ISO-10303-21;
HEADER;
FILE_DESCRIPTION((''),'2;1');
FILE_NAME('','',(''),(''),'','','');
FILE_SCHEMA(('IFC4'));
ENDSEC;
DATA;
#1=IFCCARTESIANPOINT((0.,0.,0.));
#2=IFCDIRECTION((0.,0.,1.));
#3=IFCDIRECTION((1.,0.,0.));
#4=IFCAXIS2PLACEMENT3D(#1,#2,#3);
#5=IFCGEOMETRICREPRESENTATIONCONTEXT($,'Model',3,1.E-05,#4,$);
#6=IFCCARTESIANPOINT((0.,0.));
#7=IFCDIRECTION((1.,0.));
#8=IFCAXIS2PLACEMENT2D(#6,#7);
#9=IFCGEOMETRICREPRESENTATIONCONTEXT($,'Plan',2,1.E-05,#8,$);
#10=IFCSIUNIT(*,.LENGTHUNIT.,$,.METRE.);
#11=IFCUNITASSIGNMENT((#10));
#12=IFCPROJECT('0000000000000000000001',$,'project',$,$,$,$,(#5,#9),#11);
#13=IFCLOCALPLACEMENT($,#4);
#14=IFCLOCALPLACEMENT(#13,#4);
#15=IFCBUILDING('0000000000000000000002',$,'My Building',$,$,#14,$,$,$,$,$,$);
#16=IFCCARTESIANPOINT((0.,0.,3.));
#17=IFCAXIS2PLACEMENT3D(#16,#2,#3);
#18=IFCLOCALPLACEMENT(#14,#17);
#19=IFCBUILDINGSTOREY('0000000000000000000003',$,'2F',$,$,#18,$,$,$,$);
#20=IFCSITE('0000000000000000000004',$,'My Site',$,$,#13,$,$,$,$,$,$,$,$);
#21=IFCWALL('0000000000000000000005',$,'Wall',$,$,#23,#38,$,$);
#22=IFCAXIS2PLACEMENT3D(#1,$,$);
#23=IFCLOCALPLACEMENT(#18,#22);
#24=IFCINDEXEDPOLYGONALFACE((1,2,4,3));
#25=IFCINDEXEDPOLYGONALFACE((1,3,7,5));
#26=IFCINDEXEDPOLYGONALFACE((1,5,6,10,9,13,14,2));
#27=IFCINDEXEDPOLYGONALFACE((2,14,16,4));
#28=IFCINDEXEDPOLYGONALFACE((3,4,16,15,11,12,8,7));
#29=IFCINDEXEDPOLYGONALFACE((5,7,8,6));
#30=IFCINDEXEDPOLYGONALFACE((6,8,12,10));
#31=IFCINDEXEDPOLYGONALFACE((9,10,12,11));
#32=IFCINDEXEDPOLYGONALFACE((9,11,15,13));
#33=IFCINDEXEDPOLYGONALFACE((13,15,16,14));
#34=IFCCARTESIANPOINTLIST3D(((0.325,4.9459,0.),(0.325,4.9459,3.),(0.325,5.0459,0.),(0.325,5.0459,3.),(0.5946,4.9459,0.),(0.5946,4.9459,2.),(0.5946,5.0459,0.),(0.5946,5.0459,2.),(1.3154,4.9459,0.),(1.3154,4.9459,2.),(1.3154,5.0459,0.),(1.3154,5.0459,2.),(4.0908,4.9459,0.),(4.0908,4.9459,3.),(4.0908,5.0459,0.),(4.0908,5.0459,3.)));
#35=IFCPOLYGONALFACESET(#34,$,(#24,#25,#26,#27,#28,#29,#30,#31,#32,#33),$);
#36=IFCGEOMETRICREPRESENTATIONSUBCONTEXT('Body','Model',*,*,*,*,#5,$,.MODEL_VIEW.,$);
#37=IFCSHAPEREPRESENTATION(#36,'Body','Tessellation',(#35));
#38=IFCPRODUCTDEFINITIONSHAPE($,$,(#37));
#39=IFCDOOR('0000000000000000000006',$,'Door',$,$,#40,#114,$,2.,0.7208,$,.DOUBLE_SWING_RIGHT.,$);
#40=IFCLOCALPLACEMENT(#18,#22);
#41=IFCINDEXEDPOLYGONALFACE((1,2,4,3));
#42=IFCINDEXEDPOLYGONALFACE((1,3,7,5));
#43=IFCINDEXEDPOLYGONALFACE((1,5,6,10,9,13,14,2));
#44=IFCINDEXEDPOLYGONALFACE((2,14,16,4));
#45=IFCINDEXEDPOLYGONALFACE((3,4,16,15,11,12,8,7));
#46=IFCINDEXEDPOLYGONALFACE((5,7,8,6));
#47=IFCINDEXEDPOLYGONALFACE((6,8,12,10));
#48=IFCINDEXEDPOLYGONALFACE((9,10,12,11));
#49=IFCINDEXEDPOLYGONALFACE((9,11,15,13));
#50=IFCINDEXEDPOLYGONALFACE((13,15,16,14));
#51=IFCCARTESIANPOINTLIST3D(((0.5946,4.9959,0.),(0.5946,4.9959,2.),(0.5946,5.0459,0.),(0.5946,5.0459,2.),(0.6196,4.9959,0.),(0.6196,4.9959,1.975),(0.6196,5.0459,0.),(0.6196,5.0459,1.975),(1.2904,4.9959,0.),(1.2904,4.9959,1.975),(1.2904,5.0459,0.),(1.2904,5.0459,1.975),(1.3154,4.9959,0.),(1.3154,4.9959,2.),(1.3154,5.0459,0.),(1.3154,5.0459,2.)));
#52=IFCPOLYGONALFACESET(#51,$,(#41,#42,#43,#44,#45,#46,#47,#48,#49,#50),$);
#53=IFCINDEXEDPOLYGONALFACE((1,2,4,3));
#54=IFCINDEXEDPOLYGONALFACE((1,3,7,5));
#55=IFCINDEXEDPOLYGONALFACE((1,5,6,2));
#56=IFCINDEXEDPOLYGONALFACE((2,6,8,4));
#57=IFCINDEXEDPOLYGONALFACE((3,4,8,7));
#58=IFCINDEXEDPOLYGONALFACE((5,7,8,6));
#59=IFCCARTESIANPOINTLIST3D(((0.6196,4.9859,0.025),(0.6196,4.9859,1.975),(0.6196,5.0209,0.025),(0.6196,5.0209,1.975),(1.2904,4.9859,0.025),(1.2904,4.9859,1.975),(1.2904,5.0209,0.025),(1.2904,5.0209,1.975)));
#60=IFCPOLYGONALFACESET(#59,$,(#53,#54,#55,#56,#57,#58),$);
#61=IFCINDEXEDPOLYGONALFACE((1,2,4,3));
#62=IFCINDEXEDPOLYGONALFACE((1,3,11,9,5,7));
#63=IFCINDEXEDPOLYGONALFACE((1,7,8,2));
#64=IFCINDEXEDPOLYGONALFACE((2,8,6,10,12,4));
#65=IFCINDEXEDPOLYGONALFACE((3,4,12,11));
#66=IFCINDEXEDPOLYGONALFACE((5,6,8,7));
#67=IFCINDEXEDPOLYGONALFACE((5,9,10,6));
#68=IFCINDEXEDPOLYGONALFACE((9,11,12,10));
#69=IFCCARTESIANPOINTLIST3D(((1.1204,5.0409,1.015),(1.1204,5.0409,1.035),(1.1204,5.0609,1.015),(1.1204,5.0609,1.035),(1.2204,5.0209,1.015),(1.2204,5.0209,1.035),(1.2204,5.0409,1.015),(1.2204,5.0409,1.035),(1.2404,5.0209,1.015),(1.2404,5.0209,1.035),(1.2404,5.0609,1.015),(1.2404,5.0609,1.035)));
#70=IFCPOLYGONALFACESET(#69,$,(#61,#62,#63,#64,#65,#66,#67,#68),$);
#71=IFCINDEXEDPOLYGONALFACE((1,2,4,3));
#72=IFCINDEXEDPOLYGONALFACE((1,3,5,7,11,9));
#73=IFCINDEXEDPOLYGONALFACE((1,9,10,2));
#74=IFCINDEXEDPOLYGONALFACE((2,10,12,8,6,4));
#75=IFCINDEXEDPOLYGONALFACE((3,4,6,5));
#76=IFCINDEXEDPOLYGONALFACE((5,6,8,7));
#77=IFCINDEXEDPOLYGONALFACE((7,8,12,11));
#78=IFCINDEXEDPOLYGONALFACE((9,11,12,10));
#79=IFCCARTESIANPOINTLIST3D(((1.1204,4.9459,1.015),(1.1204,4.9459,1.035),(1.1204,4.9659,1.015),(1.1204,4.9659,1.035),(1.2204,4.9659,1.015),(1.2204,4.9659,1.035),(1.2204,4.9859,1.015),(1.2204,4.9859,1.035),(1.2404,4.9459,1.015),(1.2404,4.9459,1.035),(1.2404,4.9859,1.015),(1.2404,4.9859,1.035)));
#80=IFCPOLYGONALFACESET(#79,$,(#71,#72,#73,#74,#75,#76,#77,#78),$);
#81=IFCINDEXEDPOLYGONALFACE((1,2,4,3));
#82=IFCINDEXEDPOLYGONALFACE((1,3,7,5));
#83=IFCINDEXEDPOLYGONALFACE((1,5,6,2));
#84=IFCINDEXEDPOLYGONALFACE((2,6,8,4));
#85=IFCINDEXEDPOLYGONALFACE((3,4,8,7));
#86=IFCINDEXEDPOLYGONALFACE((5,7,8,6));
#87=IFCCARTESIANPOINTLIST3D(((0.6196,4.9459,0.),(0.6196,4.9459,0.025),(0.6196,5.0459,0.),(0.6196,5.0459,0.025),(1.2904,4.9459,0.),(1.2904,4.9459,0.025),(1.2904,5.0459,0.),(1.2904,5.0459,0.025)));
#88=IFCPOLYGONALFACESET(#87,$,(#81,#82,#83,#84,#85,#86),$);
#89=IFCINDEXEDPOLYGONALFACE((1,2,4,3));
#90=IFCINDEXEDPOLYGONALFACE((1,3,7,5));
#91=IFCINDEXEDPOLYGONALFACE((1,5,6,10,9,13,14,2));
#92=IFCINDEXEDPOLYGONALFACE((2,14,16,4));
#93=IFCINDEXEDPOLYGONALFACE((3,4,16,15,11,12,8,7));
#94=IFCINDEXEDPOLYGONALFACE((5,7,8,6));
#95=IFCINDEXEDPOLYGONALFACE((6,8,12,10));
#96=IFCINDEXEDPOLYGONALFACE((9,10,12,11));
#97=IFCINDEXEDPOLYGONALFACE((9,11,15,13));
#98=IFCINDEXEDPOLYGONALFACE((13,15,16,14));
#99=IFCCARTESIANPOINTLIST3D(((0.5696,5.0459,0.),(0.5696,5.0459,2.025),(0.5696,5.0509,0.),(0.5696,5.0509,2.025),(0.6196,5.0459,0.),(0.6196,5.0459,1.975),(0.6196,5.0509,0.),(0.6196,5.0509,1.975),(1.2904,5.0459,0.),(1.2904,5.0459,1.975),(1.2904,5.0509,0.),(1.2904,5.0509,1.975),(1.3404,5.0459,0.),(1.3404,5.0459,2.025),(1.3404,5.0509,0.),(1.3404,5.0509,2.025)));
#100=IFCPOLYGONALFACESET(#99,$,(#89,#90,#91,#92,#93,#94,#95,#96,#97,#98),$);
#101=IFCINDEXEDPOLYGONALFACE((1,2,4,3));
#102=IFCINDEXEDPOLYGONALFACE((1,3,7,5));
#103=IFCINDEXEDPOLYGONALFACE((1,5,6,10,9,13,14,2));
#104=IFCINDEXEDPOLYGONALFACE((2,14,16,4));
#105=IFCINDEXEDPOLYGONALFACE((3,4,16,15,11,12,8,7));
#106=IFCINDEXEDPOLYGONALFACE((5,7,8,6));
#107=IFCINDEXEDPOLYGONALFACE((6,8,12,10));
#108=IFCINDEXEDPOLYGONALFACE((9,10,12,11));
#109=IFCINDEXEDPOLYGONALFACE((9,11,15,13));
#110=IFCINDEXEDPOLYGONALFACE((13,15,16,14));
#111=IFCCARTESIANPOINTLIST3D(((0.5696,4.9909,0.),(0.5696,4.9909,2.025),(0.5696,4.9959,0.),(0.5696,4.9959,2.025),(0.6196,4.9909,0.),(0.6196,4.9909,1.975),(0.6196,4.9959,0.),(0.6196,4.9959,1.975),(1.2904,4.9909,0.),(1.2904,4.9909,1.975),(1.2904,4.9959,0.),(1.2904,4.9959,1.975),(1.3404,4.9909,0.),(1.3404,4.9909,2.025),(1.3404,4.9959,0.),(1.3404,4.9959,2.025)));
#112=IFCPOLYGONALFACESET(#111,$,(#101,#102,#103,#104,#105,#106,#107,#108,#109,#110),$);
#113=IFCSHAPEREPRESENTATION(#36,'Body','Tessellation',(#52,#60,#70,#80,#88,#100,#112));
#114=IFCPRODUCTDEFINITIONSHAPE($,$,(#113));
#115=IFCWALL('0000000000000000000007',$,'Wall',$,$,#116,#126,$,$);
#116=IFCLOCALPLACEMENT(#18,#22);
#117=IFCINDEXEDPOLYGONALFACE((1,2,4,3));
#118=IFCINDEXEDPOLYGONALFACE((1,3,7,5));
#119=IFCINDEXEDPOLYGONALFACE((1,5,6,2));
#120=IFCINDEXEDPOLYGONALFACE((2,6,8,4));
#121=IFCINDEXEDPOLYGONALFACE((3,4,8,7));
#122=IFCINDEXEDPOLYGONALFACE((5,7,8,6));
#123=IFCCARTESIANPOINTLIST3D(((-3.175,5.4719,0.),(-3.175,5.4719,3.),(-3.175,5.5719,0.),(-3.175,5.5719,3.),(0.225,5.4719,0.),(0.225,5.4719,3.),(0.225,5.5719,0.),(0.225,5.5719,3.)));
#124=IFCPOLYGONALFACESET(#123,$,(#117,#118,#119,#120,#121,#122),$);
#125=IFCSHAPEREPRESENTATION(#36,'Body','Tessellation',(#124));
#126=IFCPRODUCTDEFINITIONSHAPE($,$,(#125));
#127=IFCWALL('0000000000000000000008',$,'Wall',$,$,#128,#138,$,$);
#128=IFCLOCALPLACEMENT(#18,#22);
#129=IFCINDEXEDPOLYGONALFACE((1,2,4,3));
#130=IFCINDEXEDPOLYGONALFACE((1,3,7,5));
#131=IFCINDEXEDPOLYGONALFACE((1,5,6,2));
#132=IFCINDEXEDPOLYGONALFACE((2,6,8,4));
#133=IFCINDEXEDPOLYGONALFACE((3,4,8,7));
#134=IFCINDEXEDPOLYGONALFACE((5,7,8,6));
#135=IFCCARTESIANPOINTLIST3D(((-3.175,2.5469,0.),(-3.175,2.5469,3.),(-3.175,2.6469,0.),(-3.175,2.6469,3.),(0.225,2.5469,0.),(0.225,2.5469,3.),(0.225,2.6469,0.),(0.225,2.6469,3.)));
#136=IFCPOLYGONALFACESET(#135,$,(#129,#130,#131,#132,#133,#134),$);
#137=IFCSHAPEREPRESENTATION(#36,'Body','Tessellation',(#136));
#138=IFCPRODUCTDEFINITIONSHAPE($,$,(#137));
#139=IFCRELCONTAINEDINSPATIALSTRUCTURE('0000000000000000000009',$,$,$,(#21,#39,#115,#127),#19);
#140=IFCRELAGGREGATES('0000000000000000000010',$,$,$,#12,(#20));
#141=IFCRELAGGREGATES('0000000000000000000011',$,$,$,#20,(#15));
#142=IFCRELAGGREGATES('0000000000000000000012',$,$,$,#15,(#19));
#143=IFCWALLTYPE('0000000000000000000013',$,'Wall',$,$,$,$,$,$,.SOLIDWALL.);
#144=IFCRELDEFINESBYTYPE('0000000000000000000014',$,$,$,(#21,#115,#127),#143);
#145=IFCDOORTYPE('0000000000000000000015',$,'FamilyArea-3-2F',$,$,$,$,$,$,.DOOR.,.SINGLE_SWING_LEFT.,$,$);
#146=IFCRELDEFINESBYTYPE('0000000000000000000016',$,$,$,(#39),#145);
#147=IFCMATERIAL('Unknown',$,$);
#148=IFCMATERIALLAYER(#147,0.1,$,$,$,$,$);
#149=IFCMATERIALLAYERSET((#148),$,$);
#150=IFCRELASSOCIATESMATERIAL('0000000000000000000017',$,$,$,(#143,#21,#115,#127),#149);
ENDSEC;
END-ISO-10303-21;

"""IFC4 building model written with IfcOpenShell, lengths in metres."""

from ifc_helpers import new_model, entity, si_unit, frame, origin_with_axes, origin_2d_with_axis, place, context, subcontext, project, spatial, line, indexed_curve, outline, extrude, shape, source, transform, mapped, material, layer, layer_set, layer_usage, type_object, type_shapes, element, fill, save


model = new_model("IFC4")

# Units and contexts
model_context = context("Model", 3, precision=1e-05, world=origin_with_axes())
plan_context = context("Plan", 2, precision=1e-05, world=origin_2d_with_axis())
body_context_1 = subcontext(model_context, "Body", "Model", "MODEL_VIEW")
body_context_2 = subcontext(plan_context, "Body", "Plan", "PLAN_VIEW")
ifc_project = project(units=[si_unit("LENGTHUNIT", "METRE")], contexts=[model_context, plan_context])

# Site, building, storey
site_placement = place(None, origin_with_axes())
site = spatial("IfcSite", under=ifc_project, at=site_placement, Name="My Site")
building_placement = place(site_placement, origin_with_axes())
building = spatial("IfcBuilding", under=site, at=building_placement, Name="My Building")
storey_placement = place(building_placement, frame((0.0, 0.0, 3.0), z_axis=(0.0, 0.0, 1.0), x_axis=(1.0, 0.0, 0.0)))
storey = spatial("IfcBuildingStorey", under=building, at=storey_placement, Name="2F")

# Shared definitions
ifc_material = material(Name="Unknown")

# Shared definitions
ifc_layer_1 = layer(ifc_material, 0.1)
ifc_layer_set_1 = layer_set([ifc_layer_1])
wall_type = type_object("IfcWallType", Name="Wall", PredefinedType="SOLIDWALL", material=ifc_layer_set_1)

# Wall, opening, door
ifc_layer_usage_1 = layer_usage(ifc_layer_set_1, "AXIS2", "POSITIVE", 0.0)
wall_1_placement = place(storey_placement, frame((4.0908, 5.0459, 0.0), z_axis=(0.0, 0.0, 1.0), x_axis=(-1.0, 0.0, 0.0)))
wall_1 = element("IfcWall", 1, at=wall_1_placement, inside=storey, type_object=wall_type, material=ifc_layer_usage_1, Name="Wall", context=body_context_1, shape_type="SweptSolid", body=[
    extrude(outline(indexed_curve([(0.0, 0.0), (0.0, 0.1), (3.7659, 0.1), (3.7659, 0.0)], segments=[line(1, 2, 3, 4, 1)])), origin_with_axes(), (0.0, 0.0, 1.0), 3.0),
])
shared_shape_1 = source(origin_with_axes(), body_context_1, "Body", "SweptSolid", [
    extrude(outline(indexed_curve([(0.0, 0.0), (0.7208, 0.0), (0.7208, 2.0), (0.0, 2.0)], segments=[line(1, 2, 3, 4, 1)])), frame((0.0, -0.6, 0.0), z_axis=(0.0, -1.0, 0.0), x_axis=(1.0, 0.0, 0.0)), (0.0, 0.0, -1.0), 1.2),
])
opening_1_placement = place(wall_1_placement, frame((2.7755, 0.0, 0.0), z_axis=(0.0, 0.0, 1.0), x_axis=(1.0, 0.0, 0.0)))
opening_1 = element("IfcOpeningElement", 2, at=opening_1_placement, cuts=wall_1, PredefinedType="OPENING", context=body_context_1, shape_type="MappedRepresentation", body=[
    mapped(shared_shape_1, transform((0.0, 0.0, 0.0), x_axis=(1.0, 0.0, 0.0), y_axis=(0.0, 1.0, 0.0), z_axis=(0.0, 0.0, 1.0), scale=1.0)),
])
door_type_1 = type_object("IfcDoorType", Name="FamilyArea-3-2F", OperationType="SINGLE_SWING_LEFT", PredefinedType="DOOR")
shared_shape_2 = source(origin_with_axes(), body_context_1, "Body", "SweptSolid", [
    extrude(outline(indexed_curve([(0.0, 0.0), (0.0, 2.0), (0.7208, 2.0), (0.7208, 0.0), (0.6958, 0.0), (0.6958, 1.975), (0.025, 1.975), (0.025, 0.0)], segments=[line(1, 2, 3, 4, 5, 6, 7, 8, 1)])), frame((0.0, 0.0, 0.0), z_axis=(0.0, -1.0, 0.0), x_axis=(1.0, 0.0, 0.0)), (0.0, 0.0, -1.0), 0.05),
    extrude(outline(indexed_curve([(0.0, 0.0), (0.6708, 0.0), (0.6708, 0.035), (0.0, 0.035)], segments=[line(1, 2, 3, 4, 1)])), frame((0.025, 0.025, 0.025), z_axis=(0.0, 0.0, 1.0), x_axis=(1.0, 0.0, 0.0)), (0.0, 0.0, 1.0), 1.95),
    extrude(outline(indexed_curve([(0.0, 0.0), (0.0, -0.04), (0.12, -0.04), (0.12, -0.02), (0.02, -0.02), (0.02, 0.0)], segments=[line(1, 2, 3, 4, 5, 6, 1)])), frame((0.075, 0.025, 1.015), z_axis=(0.0, 0.0, 1.0), x_axis=(1.0, 0.0, 0.0)), (0.0, 0.0, 1.0), 0.02),
    extrude(outline(indexed_curve([(0.0, 0.0), (0.0, 0.04), (0.12, 0.04), (0.12, 0.02), (0.02, 0.02), (0.02, 0.0)], segments=[line(1, 2, 3, 4, 5, 6, 1)])), frame((0.075, 0.06, 1.015), z_axis=(0.0, 0.0, 1.0), x_axis=(1.0, 0.0, 0.0)), (0.0, 0.0, 1.0), 0.02),
    extrude(outline(indexed_curve([(0.0, 0.0), (0.6708, 0.0), (0.6708, 0.1), (0.0, 0.1)], segments=[line(1, 2, 3, 4, 1)])), frame((0.025, 0.0, 0.0), z_axis=(0.0, 0.0, 1.0), x_axis=(1.0, 0.0, 0.0)), (0.0, 0.0, 1.0), 0.025),
    extrude(outline(indexed_curve([(0.0, 0.0), (0.0, 2.025), (0.7708, 2.025), (0.7708, 0.0), (0.7208, 0.0), (0.7208, 1.975), (0.05, 1.975), (0.05, 0.0)], segments=[line(1, 2, 3, 4, 5, 6, 7, 8, 1)])), frame((-0.025, -0.005, 0.0), z_axis=(0.0, -1.0, 0.0), x_axis=(1.0, 0.0, 0.0)), (0.0, 0.0, -1.0), 0.005),
    extrude(outline(indexed_curve([(0.0, 0.0), (0.0, 2.025), (0.7708, 2.025), (0.7708, 0.0), (0.7208, 0.0), (0.7208, 1.975), (0.05, 1.975), (0.05, 0.0)], segments=[line(1, 2, 3, 4, 5, 6, 7, 8, 1)])), frame((-0.025, 0.05, 0.0), z_axis=(0.0, -1.0, 0.0), x_axis=(1.0, 0.0, 0.0)), (0.0, 0.0, -1.0), 0.005),
])
shared_shape_3 = source(origin_with_axes(), body_context_2, "Body", "Curve2D", [
    entity("IfcIndexedPolyCurve", entity("IfcCartesianPointList2D", [[0.0, 0.0], [0.025, 0.0], [0.025, 0.05], [0.0, 0.05]]), [entity("IfcLineIndex", [1, 2, 3, 4, 1])]),
    entity("IfcIndexedPolyCurve", entity("IfcCartesianPointList2D", [[0.7208, 0.0], [0.6958, 0.0], [0.6958, 0.05], [0.7208, 0.05]]), [entity("IfcLineIndex", [1, 2, 3, 4, 1])]),
    entity("IfcIndexedPolyCurve", entity("IfcCartesianPointList2D", [[0.6958, 0.05], [0.6958, -0.6208], [0.6608, -0.6208]])),
    entity("IfcTrimmedCurve", entity("IfcEllipse", entity("IfcAxis2Placement2D", entity("IfcCartesianPoint", [0.6608, 0.05]), entity("IfcDirection", [1.0, 0.0])), 0.6358, 0.6708), [entity("IfcCartesianPoint", [0.6608, 0.7208])], [entity("IfcCartesianPoint", [0.6608, -0.6208])], True, "CARTESIAN"),
    entity("IfcIndexedPolyCurve", entity("IfcCartesianPointList2D", [[0.6958, 0.05], [0.6608, 0.05], [0.6608, 0.7208], [0.6958, 0.7208]]), [entity("IfcLineIndex", [1, 2, 3, 4, 1])]),
])
type_shapes(door_type_1, [shared_shape_2, shared_shape_3])
door_1_placement = place(opening_1_placement, frame((0.0, 0.0, 0.0), z_axis=(0.0, 0.0, 1.0), x_axis=(1.0, 0.0, 0.0)))
door_1 = element("IfcDoor", 3, at=door_1_placement, inside=storey, type_object=door_type_1, Name="Door", OperationType="DOUBLE_SWING_RIGHT", OverallHeight=2.0, OverallWidth=0.7208, shapes=[
    shape(body_context_1, "Body", "MappedRepresentation", [mapped(shared_shape_2, transform((0.0, 0.0, 0.0), x_axis=(1.0, 0.0, 0.0), y_axis=(0.0, 1.0, 0.0), z_axis=(0.0, 0.0, 1.0), scale=1.0))]),
    shape(body_context_2, "Body", "MappedRepresentation", [mapped(shared_shape_3, transform((0.0, 0.0, 0.0), x_axis=(1.0, 0.0, 0.0), y_axis=(0.0, 1.0, 0.0), z_axis=(0.0, 0.0, 1.0), scale=1.0))]),
])
fill(opening_1, door_1)

# Walls
ifc_layer_usage_2 = layer_usage(ifc_layer_set_1, "AXIS2", "POSITIVE", 0.0)
wall_2_placement = place(storey_placement, frame((-3.175, 5.4719, 0.0), z_axis=(0.0, 0.0, 1.0), x_axis=(1.0, 0.0, 0.0)))
element("IfcWall", 4, at=wall_2_placement, inside=storey, type_object=wall_type, material=ifc_layer_usage_2, Name="Wall", context=body_context_1, shape_type="SweptSolid", body=[
    extrude(outline(indexed_curve([(0.0, 0.0), (0.0, 0.1), (3.4, 0.1), (3.4, 0.0)], segments=[line(1, 2, 3, 4, 1)])), origin_with_axes(), (0.0, 0.0, 1.0), 3.0),
])
ifc_layer_usage_3 = layer_usage(ifc_layer_set_1, "AXIS2", "POSITIVE", 0.0)
wall_3_placement = place(storey_placement, frame((-3.175, 2.5469, 0.0), z_axis=(0.0, 0.0, 1.0), x_axis=(1.0, 0.0, 0.0)))
element("IfcWall", 5, at=wall_3_placement, inside=storey, type_object=wall_type, material=ifc_layer_usage_3, Name="Wall", context=body_context_1, shape_type="SweptSolid", body=[
    extrude(outline(indexed_curve([(0.0, 0.0), (0.0, 0.1), (3.4, 0.1), (3.4, 0.0)], segments=[line(1, 2, 3, 4, 1)])), origin_with_axes(), (0.0, 0.0, 1.0), 3.0),
])

save(model, "model.ifc")
